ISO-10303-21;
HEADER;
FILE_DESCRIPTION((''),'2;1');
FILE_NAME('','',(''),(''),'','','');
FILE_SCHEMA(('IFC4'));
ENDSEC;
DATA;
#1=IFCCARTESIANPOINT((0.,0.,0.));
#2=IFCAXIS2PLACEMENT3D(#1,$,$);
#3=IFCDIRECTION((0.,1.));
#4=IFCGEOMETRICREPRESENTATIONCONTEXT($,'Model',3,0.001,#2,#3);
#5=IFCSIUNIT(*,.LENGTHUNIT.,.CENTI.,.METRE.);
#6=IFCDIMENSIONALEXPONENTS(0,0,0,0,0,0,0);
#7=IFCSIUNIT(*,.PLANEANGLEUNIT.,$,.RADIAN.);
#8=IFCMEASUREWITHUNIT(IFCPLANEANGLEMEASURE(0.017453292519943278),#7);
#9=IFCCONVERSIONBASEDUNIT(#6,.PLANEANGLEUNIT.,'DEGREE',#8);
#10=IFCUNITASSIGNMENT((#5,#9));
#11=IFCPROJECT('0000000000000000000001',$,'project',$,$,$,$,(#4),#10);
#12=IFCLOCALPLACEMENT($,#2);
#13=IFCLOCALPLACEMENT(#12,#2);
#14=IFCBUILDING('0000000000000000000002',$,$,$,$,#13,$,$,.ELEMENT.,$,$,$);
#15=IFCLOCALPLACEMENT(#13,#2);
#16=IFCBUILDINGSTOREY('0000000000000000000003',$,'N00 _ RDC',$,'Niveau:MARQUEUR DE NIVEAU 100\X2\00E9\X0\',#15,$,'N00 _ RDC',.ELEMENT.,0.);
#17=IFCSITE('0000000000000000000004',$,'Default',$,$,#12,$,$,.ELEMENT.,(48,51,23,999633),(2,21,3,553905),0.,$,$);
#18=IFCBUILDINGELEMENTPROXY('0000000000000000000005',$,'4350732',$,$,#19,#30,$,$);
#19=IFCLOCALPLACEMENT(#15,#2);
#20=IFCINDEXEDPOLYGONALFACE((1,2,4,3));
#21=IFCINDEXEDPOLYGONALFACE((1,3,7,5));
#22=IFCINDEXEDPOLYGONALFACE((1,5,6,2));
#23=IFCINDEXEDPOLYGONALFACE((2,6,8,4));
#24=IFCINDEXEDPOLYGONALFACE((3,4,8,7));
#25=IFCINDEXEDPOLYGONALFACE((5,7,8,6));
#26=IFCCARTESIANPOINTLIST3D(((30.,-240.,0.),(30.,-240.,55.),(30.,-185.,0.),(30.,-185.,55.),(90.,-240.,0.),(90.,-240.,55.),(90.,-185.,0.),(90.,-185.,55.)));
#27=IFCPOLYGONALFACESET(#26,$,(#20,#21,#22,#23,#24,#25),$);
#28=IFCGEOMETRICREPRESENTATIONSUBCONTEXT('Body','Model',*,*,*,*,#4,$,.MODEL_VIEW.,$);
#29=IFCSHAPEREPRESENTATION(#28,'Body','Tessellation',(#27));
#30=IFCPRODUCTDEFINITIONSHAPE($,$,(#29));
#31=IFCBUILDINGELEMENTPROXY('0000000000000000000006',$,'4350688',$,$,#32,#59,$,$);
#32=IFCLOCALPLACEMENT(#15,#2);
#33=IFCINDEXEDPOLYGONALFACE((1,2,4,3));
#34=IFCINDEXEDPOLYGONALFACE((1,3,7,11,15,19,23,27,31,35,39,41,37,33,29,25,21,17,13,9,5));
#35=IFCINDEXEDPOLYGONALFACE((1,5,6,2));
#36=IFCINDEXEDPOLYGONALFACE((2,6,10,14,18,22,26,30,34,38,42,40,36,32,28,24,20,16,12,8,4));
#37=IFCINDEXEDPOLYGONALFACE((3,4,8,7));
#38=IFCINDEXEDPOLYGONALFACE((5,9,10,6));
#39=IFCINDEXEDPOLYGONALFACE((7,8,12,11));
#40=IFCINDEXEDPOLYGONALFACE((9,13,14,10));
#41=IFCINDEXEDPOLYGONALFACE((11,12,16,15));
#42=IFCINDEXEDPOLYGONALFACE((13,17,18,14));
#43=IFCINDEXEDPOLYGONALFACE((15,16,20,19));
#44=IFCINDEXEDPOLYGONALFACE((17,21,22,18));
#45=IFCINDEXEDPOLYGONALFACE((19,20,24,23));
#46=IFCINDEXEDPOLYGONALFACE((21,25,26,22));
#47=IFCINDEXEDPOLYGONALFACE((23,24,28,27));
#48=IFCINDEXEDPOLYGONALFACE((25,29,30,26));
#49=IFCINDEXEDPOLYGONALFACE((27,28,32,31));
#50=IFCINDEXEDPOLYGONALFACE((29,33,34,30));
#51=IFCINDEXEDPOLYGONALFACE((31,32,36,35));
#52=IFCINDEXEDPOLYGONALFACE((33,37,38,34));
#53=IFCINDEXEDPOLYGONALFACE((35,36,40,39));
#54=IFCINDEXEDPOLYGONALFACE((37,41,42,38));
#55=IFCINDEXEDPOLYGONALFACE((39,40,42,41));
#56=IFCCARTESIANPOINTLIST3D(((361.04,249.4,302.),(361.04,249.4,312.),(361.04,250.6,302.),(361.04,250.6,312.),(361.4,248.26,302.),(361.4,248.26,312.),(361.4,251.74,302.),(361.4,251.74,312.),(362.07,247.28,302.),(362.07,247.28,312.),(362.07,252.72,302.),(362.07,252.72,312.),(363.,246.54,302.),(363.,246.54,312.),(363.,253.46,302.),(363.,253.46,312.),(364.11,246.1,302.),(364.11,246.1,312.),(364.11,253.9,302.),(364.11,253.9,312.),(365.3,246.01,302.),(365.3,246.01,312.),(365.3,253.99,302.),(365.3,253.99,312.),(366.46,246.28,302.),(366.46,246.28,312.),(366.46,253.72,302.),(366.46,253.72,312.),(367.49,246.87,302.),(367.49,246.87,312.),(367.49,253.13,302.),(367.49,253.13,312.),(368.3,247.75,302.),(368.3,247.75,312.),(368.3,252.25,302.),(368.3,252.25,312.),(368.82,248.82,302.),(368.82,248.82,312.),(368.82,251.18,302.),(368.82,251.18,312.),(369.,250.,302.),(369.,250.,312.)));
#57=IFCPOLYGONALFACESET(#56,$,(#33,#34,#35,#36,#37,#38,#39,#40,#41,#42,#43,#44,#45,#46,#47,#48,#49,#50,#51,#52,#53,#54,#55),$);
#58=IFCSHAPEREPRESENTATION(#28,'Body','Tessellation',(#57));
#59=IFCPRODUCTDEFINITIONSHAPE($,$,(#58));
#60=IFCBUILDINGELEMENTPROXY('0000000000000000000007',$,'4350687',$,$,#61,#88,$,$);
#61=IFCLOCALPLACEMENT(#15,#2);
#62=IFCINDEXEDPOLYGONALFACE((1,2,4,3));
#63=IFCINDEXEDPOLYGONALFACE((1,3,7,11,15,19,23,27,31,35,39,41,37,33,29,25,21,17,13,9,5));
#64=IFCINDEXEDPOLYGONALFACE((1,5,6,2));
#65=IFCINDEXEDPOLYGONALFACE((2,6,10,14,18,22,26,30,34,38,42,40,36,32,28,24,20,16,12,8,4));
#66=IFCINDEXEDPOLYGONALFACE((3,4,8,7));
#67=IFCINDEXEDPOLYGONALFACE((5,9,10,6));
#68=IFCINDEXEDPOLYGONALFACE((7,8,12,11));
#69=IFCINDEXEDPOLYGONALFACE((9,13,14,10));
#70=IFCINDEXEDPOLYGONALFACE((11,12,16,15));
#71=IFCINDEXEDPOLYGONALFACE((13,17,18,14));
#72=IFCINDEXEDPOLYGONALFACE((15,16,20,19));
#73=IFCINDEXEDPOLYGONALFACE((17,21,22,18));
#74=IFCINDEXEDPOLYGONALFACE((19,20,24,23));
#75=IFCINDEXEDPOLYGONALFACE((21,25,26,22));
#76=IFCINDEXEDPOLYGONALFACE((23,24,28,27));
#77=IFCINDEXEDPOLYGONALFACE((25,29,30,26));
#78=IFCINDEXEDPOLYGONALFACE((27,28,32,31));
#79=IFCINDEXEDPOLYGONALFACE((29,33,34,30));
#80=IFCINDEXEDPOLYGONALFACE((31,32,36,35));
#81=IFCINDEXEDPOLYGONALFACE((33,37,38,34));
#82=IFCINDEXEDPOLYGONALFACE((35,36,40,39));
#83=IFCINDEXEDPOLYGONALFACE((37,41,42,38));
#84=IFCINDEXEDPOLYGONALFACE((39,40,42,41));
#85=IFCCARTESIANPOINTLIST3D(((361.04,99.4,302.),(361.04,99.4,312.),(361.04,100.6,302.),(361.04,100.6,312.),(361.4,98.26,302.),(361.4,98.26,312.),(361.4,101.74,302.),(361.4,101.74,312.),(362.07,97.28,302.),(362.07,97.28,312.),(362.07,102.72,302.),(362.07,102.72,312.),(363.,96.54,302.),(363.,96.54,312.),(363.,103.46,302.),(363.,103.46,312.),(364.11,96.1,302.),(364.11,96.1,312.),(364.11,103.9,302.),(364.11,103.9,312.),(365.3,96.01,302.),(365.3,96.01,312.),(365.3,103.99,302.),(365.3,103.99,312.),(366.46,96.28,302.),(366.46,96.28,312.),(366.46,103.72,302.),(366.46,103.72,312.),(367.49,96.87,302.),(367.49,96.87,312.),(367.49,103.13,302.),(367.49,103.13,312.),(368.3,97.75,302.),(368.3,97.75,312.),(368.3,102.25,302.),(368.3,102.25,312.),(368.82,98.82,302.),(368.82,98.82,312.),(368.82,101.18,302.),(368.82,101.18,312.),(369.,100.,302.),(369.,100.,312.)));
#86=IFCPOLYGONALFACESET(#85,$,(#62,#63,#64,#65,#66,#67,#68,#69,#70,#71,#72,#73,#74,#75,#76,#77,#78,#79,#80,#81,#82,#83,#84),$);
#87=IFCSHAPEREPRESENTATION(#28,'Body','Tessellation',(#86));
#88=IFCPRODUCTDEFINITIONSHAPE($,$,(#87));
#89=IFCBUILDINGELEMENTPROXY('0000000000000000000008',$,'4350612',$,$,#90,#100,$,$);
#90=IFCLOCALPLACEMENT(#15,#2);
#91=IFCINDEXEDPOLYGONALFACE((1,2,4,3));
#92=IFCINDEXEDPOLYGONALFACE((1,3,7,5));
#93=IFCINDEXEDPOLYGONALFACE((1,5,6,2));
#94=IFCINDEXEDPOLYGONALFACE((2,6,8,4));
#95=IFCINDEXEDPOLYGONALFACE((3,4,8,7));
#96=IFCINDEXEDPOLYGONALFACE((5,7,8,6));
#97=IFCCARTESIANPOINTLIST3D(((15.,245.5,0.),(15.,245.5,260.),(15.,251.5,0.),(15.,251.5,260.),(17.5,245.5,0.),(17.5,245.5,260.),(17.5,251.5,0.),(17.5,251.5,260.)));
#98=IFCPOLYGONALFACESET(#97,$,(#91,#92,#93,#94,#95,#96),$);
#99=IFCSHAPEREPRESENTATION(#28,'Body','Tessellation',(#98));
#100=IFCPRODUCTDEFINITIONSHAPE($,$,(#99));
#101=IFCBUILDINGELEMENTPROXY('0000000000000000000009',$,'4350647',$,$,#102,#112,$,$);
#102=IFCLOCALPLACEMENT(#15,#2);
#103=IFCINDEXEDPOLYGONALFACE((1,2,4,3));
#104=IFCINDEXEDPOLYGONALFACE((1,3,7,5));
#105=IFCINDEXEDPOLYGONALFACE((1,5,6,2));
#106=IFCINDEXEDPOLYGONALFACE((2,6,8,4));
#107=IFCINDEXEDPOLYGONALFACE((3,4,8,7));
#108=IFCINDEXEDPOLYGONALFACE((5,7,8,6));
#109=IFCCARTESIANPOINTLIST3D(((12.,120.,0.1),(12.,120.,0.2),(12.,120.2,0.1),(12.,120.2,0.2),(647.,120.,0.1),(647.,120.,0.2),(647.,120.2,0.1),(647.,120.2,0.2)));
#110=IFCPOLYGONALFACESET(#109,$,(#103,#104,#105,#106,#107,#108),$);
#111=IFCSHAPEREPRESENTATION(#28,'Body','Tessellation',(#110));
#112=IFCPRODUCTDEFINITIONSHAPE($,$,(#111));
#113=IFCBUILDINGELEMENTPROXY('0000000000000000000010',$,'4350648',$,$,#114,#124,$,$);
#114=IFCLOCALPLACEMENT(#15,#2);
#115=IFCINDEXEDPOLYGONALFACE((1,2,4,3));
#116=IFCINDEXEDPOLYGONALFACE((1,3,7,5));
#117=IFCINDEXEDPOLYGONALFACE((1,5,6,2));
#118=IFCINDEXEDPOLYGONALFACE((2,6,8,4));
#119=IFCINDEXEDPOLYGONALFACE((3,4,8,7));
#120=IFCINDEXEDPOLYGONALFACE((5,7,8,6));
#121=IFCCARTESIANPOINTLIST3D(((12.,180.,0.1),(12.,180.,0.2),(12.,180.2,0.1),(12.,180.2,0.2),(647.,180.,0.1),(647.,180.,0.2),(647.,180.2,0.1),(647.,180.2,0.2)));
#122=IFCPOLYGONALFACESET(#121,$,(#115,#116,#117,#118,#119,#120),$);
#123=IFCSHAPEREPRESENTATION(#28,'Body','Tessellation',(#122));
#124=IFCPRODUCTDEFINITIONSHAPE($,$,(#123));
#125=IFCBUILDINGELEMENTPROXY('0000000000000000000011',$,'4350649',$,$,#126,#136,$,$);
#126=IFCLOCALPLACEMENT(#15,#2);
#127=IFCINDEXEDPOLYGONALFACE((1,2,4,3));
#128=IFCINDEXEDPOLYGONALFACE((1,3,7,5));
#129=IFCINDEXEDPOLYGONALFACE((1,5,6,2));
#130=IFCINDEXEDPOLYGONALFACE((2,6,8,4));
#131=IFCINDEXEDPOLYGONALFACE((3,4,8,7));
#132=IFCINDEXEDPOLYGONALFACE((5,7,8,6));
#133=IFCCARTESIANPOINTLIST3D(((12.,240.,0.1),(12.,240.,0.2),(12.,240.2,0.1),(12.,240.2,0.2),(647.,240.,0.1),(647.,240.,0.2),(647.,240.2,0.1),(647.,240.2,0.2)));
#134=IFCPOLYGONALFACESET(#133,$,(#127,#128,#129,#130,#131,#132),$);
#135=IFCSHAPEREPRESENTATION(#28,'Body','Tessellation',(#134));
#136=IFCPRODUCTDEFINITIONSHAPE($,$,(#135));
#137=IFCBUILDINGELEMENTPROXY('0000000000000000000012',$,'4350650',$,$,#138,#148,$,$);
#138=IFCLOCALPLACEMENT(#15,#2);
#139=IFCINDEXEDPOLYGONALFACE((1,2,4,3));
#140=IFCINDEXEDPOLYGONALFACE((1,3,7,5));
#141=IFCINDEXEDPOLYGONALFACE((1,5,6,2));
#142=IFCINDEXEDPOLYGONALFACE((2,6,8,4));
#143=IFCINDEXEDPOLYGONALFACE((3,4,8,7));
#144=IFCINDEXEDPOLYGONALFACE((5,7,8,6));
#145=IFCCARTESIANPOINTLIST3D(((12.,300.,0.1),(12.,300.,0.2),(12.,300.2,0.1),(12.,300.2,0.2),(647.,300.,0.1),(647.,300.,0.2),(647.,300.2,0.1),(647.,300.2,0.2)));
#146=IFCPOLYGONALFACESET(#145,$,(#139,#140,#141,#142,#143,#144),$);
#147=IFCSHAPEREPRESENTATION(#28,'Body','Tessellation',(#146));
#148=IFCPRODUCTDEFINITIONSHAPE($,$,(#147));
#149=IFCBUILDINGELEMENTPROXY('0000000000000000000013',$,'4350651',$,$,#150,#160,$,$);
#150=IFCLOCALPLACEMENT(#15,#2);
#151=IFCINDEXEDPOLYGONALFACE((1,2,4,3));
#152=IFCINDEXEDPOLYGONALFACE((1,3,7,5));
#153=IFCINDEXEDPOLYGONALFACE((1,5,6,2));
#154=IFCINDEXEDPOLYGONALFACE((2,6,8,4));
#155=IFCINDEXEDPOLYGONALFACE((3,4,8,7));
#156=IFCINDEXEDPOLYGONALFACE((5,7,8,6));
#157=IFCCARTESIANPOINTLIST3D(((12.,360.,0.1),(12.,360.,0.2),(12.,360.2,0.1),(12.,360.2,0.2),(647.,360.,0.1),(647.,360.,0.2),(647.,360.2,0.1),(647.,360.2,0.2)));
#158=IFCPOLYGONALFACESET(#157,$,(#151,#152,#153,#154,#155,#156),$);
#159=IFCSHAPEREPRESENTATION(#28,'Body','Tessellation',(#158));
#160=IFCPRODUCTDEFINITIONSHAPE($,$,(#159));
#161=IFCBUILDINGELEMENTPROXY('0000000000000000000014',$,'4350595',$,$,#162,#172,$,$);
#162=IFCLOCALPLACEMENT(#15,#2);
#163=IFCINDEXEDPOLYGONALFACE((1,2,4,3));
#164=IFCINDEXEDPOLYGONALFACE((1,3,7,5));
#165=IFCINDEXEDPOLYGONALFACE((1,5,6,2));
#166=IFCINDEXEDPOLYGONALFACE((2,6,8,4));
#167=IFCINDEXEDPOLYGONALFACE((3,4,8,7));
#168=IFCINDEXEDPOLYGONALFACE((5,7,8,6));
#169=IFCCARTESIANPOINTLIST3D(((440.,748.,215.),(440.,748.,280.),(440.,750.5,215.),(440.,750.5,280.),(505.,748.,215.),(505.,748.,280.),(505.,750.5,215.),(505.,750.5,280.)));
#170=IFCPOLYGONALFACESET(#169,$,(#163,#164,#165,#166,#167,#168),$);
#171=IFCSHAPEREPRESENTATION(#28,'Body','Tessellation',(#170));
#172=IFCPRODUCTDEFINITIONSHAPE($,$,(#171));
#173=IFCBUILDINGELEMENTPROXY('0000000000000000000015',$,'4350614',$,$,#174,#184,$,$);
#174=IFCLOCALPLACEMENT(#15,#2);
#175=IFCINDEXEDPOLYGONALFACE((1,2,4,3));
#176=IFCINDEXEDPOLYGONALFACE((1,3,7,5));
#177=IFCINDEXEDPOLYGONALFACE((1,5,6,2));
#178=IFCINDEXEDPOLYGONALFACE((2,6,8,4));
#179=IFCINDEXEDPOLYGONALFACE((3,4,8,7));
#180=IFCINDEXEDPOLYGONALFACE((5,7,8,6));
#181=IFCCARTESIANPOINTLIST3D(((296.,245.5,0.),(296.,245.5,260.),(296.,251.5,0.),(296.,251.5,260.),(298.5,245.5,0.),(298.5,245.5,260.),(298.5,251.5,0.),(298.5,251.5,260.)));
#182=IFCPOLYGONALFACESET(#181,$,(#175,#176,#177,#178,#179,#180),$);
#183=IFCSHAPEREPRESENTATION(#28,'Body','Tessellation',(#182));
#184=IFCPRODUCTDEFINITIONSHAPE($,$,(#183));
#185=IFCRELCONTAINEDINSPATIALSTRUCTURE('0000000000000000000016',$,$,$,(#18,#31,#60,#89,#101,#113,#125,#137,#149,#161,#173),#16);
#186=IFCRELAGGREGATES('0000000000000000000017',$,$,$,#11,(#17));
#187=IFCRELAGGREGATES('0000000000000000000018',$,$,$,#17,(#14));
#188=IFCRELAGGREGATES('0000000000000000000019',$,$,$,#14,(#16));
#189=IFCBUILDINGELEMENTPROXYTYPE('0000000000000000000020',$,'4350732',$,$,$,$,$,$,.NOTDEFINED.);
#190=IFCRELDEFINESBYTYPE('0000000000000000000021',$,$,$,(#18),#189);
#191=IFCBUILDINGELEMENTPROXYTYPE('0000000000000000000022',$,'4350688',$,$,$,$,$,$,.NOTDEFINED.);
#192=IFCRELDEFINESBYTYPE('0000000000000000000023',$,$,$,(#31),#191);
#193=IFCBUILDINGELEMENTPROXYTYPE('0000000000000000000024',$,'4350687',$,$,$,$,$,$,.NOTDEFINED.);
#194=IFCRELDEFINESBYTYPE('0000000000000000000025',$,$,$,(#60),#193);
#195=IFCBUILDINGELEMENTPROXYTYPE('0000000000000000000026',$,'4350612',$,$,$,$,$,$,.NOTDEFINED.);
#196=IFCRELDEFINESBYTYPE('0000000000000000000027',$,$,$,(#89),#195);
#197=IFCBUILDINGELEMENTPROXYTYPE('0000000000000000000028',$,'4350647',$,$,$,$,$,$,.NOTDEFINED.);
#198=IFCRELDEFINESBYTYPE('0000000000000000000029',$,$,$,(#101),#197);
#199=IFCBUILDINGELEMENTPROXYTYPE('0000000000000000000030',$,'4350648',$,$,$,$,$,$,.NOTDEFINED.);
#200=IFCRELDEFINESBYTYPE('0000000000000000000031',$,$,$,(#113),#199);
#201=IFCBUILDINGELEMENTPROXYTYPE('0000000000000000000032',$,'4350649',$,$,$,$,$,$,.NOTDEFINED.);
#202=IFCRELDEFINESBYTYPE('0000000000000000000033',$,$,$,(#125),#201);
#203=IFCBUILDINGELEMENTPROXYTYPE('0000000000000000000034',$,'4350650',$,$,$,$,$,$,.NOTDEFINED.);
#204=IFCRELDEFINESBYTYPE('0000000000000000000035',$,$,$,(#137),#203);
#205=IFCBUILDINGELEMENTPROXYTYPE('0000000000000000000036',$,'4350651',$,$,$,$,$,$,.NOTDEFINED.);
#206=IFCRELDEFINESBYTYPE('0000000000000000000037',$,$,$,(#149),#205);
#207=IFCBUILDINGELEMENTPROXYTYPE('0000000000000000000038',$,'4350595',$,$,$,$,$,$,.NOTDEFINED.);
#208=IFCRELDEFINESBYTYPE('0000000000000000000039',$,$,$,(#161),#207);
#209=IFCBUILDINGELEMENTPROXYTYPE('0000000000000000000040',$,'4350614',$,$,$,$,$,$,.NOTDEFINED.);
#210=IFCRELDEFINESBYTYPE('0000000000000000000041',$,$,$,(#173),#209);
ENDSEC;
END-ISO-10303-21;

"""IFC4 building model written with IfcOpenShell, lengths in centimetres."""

from ifc_helpers import new_model, entity, si_unit, converted_unit, direction, frame, frame_2d, origin, origin_2d_with_axis, place, context, subcontext, project, spatial, rectangle, circle, extrude, type_object, element, save


model = new_model("IFC4")

# Units and contexts
model_context = context("Model", 3, precision=0.001, world=origin(), true_north=direction((0.0, 1.0)))
body_context = subcontext(model_context, "Body", "Model", "MODEL_VIEW")
ifc_project = project(units=[si_unit("LENGTHUNIT", "METRE", prefix="CENTI"), converted_unit("PLANEANGLEUNIT", "DEGREE", entity("IfcPlaneAngleMeasure", 0.017453292519943278), si_unit("PLANEANGLEUNIT", "RADIAN"), dimensions=[0, 0, 0, 0, 0, 0, 0])], contexts=[model_context])

# Site, building, storey
site_placement = place(None, origin())
site = spatial("IfcSite", under=ifc_project, at=site_placement, Name="Default", CompositionType="ELEMENT", RefLatitude=(48, 51, 23, 999633), RefLongitude=(2, 21, 3, 553905), RefElevation=0.0)
building_placement = place(site_placement, origin())
building = spatial("IfcBuilding", under=site, at=building_placement, CompositionType="ELEMENT")
storey_placement = place(building_placement, origin())
storey = spatial("IfcBuildingStorey", under=building, at=storey_placement, Name="N00 _ RDC", ObjectType="Niveau:MARQUEUR DE NIVEAU 100é", LongName="N00 _ RDC", CompositionType="ELEMENT", Elevation=0.0)

# Building element proxies
building_element_proxy_type_1 = type_object("IfcBuildingElementProxyType", Name="4350732", PredefinedType="NOTDEFINED")
proxy_1_placement = place(storey_placement, origin())
element("IfcBuildingElementProxy", 1, at=proxy_1_placement, inside=storey, type_object=building_element_proxy_type_1, Name="4350732", context=body_context, shape_type="SweptSolid", body=[
    extrude(rectangle(XDim=60.0, YDim=55.0, at=frame_2d((0.0, 0.0), x_axis=(1.0, 0.0))), frame((60.0, -212.5, 0.0)), (0.0, 0.0, 1.0), 55.0),
])
building_element_proxy_type_2 = type_object("IfcBuildingElementProxyType", Name="4350688", PredefinedType="NOTDEFINED")
proxy_2_placement = place(storey_placement, origin())
element("IfcBuildingElementProxy", 2, at=proxy_2_placement, inside=storey, type_object=building_element_proxy_type_2, Name="4350688", context=body_context, shape_type="SweptSolid", body=[
    extrude(circle(Radius=4.0, at=origin_2d_with_axis()), frame((365.0, 250.0, 302.0)), (0.0, 0.0, 1.0), 10.0),
])
building_element_proxy_type_3 = type_object("IfcBuildingElementProxyType", Name="4350687", PredefinedType="NOTDEFINED")
proxy_3_placement = place(storey_placement, origin())
element("IfcBuildingElementProxy", 3, at=proxy_3_placement, inside=storey, type_object=building_element_proxy_type_3, Name="4350687", context=body_context, shape_type="SweptSolid", body=[
    extrude(circle(Radius=4.0, at=origin_2d_with_axis()), frame((365.0, 100.0, 302.0)), (0.0, 0.0, 1.0), 10.0),
])
building_element_proxy_type_4 = type_object("IfcBuildingElementProxyType", Name="4350612", PredefinedType="NOTDEFINED")
proxy_4_placement = place(storey_placement, origin())
element("IfcBuildingElementProxy", 4, at=proxy_4_placement, inside=storey, type_object=building_element_proxy_type_4, Name="4350612", context=body_context, shape_type="SweptSolid", body=[
    extrude(rectangle(XDim=2.5, YDim=6.0, at=frame_2d((0.0, 0.0), x_axis=(1.0, 0.0))), frame((16.25, 248.5, 0.0)), (0.0, 0.0, 1.0), 260.0),
])
building_element_proxy_type_5 = type_object("IfcBuildingElementProxyType", Name="4350647", PredefinedType="NOTDEFINED")
proxy_5_placement = place(storey_placement, origin())
element("IfcBuildingElementProxy", 5, at=proxy_5_placement, inside=storey, type_object=building_element_proxy_type_5, Name="4350647", context=body_context, shape_type="SweptSolid", body=[
    extrude(rectangle(XDim=635.0, YDim=0.2, at=frame_2d((0.0, 0.0), x_axis=(1.0, 0.0))), frame((329.5, 120.1, 0.1)), (0.0, 0.0, 1.0), 0.1),
])
building_element_proxy_type_6 = type_object("IfcBuildingElementProxyType", Name="4350648", PredefinedType="NOTDEFINED")
proxy_6_placement = place(storey_placement, origin())
element("IfcBuildingElementProxy", 6, at=proxy_6_placement, inside=storey, type_object=building_element_proxy_type_6, Name="4350648", context=body_context, shape_type="SweptSolid", body=[
    extrude(rectangle(XDim=635.0, YDim=0.2, at=frame_2d((0.0, 0.0), x_axis=(1.0, 0.0))), frame((329.5, 180.1, 0.1)), (0.0, 0.0, 1.0), 0.1),
])
building_element_proxy_type_7 = type_object("IfcBuildingElementProxyType", Name="4350649", PredefinedType="NOTDEFINED")
proxy_7_placement = place(storey_placement, origin())
element("IfcBuildingElementProxy", 7, at=proxy_7_placement, inside=storey, type_object=building_element_proxy_type_7, Name="4350649", context=body_context, shape_type="SweptSolid", body=[
    extrude(rectangle(XDim=635.0, YDim=0.2, at=frame_2d((0.0, 0.0), x_axis=(1.0, 0.0))), frame((329.5, 240.1, 0.1)), (0.0, 0.0, 1.0), 0.1),
])
building_element_proxy_type_8 = type_object("IfcBuildingElementProxyType", Name="4350650", PredefinedType="NOTDEFINED")
proxy_8_placement = place(storey_placement, origin())
element("IfcBuildingElementProxy", 8, at=proxy_8_placement, inside=storey, type_object=building_element_proxy_type_8, Name="4350650", context=body_context, shape_type="SweptSolid", body=[
    extrude(rectangle(XDim=635.0, YDim=0.2, at=frame_2d((0.0, 0.0), x_axis=(1.0, 0.0))), frame((329.5, 300.1, 0.1)), (0.0, 0.0, 1.0), 0.1),
])
building_element_proxy_type_9 = type_object("IfcBuildingElementProxyType", Name="4350651", PredefinedType="NOTDEFINED")
proxy_9_placement = place(storey_placement, origin())
element("IfcBuildingElementProxy", 9, at=proxy_9_placement, inside=storey, type_object=building_element_proxy_type_9, Name="4350651", context=body_context, shape_type="SweptSolid", body=[
    extrude(rectangle(XDim=635.0, YDim=0.2, at=frame_2d((0.0, 0.0), x_axis=(1.0, 0.0))), frame((329.5, 360.1, 0.1)), (0.0, 0.0, 1.0), 0.1),
])
building_element_proxy_type_10 = type_object("IfcBuildingElementProxyType", Name="4350595", PredefinedType="NOTDEFINED")
proxy_10_placement = place(storey_placement, origin())
element("IfcBuildingElementProxy", 10, at=proxy_10_placement, inside=storey, type_object=building_element_proxy_type_10, Name="4350595", context=body_context, shape_type="SweptSolid", body=[
    extrude(rectangle(XDim=65.0, YDim=2.5, at=frame_2d((0.0, 0.0), x_axis=(1.0, 0.0))), frame((472.5, 749.25, 215.0)), (0.0, 0.0, 1.0), 65.0),
])
building_element_proxy_type_11 = type_object("IfcBuildingElementProxyType", Name="4350614", PredefinedType="NOTDEFINED")
proxy_11_placement = place(storey_placement, origin())
element("IfcBuildingElementProxy", 11, at=proxy_11_placement, inside=storey, type_object=building_element_proxy_type_11, Name="4350614", context=body_context, shape_type="SweptSolid", body=[
    extrude(rectangle(XDim=2.5, YDim=6.0, at=frame_2d((0.0, 0.0), x_axis=(1.0, 0.0))), frame((297.25, 248.5, 0.0)), (0.0, 0.0, 1.0), 260.0),
])

save(model, "model.ifc")
